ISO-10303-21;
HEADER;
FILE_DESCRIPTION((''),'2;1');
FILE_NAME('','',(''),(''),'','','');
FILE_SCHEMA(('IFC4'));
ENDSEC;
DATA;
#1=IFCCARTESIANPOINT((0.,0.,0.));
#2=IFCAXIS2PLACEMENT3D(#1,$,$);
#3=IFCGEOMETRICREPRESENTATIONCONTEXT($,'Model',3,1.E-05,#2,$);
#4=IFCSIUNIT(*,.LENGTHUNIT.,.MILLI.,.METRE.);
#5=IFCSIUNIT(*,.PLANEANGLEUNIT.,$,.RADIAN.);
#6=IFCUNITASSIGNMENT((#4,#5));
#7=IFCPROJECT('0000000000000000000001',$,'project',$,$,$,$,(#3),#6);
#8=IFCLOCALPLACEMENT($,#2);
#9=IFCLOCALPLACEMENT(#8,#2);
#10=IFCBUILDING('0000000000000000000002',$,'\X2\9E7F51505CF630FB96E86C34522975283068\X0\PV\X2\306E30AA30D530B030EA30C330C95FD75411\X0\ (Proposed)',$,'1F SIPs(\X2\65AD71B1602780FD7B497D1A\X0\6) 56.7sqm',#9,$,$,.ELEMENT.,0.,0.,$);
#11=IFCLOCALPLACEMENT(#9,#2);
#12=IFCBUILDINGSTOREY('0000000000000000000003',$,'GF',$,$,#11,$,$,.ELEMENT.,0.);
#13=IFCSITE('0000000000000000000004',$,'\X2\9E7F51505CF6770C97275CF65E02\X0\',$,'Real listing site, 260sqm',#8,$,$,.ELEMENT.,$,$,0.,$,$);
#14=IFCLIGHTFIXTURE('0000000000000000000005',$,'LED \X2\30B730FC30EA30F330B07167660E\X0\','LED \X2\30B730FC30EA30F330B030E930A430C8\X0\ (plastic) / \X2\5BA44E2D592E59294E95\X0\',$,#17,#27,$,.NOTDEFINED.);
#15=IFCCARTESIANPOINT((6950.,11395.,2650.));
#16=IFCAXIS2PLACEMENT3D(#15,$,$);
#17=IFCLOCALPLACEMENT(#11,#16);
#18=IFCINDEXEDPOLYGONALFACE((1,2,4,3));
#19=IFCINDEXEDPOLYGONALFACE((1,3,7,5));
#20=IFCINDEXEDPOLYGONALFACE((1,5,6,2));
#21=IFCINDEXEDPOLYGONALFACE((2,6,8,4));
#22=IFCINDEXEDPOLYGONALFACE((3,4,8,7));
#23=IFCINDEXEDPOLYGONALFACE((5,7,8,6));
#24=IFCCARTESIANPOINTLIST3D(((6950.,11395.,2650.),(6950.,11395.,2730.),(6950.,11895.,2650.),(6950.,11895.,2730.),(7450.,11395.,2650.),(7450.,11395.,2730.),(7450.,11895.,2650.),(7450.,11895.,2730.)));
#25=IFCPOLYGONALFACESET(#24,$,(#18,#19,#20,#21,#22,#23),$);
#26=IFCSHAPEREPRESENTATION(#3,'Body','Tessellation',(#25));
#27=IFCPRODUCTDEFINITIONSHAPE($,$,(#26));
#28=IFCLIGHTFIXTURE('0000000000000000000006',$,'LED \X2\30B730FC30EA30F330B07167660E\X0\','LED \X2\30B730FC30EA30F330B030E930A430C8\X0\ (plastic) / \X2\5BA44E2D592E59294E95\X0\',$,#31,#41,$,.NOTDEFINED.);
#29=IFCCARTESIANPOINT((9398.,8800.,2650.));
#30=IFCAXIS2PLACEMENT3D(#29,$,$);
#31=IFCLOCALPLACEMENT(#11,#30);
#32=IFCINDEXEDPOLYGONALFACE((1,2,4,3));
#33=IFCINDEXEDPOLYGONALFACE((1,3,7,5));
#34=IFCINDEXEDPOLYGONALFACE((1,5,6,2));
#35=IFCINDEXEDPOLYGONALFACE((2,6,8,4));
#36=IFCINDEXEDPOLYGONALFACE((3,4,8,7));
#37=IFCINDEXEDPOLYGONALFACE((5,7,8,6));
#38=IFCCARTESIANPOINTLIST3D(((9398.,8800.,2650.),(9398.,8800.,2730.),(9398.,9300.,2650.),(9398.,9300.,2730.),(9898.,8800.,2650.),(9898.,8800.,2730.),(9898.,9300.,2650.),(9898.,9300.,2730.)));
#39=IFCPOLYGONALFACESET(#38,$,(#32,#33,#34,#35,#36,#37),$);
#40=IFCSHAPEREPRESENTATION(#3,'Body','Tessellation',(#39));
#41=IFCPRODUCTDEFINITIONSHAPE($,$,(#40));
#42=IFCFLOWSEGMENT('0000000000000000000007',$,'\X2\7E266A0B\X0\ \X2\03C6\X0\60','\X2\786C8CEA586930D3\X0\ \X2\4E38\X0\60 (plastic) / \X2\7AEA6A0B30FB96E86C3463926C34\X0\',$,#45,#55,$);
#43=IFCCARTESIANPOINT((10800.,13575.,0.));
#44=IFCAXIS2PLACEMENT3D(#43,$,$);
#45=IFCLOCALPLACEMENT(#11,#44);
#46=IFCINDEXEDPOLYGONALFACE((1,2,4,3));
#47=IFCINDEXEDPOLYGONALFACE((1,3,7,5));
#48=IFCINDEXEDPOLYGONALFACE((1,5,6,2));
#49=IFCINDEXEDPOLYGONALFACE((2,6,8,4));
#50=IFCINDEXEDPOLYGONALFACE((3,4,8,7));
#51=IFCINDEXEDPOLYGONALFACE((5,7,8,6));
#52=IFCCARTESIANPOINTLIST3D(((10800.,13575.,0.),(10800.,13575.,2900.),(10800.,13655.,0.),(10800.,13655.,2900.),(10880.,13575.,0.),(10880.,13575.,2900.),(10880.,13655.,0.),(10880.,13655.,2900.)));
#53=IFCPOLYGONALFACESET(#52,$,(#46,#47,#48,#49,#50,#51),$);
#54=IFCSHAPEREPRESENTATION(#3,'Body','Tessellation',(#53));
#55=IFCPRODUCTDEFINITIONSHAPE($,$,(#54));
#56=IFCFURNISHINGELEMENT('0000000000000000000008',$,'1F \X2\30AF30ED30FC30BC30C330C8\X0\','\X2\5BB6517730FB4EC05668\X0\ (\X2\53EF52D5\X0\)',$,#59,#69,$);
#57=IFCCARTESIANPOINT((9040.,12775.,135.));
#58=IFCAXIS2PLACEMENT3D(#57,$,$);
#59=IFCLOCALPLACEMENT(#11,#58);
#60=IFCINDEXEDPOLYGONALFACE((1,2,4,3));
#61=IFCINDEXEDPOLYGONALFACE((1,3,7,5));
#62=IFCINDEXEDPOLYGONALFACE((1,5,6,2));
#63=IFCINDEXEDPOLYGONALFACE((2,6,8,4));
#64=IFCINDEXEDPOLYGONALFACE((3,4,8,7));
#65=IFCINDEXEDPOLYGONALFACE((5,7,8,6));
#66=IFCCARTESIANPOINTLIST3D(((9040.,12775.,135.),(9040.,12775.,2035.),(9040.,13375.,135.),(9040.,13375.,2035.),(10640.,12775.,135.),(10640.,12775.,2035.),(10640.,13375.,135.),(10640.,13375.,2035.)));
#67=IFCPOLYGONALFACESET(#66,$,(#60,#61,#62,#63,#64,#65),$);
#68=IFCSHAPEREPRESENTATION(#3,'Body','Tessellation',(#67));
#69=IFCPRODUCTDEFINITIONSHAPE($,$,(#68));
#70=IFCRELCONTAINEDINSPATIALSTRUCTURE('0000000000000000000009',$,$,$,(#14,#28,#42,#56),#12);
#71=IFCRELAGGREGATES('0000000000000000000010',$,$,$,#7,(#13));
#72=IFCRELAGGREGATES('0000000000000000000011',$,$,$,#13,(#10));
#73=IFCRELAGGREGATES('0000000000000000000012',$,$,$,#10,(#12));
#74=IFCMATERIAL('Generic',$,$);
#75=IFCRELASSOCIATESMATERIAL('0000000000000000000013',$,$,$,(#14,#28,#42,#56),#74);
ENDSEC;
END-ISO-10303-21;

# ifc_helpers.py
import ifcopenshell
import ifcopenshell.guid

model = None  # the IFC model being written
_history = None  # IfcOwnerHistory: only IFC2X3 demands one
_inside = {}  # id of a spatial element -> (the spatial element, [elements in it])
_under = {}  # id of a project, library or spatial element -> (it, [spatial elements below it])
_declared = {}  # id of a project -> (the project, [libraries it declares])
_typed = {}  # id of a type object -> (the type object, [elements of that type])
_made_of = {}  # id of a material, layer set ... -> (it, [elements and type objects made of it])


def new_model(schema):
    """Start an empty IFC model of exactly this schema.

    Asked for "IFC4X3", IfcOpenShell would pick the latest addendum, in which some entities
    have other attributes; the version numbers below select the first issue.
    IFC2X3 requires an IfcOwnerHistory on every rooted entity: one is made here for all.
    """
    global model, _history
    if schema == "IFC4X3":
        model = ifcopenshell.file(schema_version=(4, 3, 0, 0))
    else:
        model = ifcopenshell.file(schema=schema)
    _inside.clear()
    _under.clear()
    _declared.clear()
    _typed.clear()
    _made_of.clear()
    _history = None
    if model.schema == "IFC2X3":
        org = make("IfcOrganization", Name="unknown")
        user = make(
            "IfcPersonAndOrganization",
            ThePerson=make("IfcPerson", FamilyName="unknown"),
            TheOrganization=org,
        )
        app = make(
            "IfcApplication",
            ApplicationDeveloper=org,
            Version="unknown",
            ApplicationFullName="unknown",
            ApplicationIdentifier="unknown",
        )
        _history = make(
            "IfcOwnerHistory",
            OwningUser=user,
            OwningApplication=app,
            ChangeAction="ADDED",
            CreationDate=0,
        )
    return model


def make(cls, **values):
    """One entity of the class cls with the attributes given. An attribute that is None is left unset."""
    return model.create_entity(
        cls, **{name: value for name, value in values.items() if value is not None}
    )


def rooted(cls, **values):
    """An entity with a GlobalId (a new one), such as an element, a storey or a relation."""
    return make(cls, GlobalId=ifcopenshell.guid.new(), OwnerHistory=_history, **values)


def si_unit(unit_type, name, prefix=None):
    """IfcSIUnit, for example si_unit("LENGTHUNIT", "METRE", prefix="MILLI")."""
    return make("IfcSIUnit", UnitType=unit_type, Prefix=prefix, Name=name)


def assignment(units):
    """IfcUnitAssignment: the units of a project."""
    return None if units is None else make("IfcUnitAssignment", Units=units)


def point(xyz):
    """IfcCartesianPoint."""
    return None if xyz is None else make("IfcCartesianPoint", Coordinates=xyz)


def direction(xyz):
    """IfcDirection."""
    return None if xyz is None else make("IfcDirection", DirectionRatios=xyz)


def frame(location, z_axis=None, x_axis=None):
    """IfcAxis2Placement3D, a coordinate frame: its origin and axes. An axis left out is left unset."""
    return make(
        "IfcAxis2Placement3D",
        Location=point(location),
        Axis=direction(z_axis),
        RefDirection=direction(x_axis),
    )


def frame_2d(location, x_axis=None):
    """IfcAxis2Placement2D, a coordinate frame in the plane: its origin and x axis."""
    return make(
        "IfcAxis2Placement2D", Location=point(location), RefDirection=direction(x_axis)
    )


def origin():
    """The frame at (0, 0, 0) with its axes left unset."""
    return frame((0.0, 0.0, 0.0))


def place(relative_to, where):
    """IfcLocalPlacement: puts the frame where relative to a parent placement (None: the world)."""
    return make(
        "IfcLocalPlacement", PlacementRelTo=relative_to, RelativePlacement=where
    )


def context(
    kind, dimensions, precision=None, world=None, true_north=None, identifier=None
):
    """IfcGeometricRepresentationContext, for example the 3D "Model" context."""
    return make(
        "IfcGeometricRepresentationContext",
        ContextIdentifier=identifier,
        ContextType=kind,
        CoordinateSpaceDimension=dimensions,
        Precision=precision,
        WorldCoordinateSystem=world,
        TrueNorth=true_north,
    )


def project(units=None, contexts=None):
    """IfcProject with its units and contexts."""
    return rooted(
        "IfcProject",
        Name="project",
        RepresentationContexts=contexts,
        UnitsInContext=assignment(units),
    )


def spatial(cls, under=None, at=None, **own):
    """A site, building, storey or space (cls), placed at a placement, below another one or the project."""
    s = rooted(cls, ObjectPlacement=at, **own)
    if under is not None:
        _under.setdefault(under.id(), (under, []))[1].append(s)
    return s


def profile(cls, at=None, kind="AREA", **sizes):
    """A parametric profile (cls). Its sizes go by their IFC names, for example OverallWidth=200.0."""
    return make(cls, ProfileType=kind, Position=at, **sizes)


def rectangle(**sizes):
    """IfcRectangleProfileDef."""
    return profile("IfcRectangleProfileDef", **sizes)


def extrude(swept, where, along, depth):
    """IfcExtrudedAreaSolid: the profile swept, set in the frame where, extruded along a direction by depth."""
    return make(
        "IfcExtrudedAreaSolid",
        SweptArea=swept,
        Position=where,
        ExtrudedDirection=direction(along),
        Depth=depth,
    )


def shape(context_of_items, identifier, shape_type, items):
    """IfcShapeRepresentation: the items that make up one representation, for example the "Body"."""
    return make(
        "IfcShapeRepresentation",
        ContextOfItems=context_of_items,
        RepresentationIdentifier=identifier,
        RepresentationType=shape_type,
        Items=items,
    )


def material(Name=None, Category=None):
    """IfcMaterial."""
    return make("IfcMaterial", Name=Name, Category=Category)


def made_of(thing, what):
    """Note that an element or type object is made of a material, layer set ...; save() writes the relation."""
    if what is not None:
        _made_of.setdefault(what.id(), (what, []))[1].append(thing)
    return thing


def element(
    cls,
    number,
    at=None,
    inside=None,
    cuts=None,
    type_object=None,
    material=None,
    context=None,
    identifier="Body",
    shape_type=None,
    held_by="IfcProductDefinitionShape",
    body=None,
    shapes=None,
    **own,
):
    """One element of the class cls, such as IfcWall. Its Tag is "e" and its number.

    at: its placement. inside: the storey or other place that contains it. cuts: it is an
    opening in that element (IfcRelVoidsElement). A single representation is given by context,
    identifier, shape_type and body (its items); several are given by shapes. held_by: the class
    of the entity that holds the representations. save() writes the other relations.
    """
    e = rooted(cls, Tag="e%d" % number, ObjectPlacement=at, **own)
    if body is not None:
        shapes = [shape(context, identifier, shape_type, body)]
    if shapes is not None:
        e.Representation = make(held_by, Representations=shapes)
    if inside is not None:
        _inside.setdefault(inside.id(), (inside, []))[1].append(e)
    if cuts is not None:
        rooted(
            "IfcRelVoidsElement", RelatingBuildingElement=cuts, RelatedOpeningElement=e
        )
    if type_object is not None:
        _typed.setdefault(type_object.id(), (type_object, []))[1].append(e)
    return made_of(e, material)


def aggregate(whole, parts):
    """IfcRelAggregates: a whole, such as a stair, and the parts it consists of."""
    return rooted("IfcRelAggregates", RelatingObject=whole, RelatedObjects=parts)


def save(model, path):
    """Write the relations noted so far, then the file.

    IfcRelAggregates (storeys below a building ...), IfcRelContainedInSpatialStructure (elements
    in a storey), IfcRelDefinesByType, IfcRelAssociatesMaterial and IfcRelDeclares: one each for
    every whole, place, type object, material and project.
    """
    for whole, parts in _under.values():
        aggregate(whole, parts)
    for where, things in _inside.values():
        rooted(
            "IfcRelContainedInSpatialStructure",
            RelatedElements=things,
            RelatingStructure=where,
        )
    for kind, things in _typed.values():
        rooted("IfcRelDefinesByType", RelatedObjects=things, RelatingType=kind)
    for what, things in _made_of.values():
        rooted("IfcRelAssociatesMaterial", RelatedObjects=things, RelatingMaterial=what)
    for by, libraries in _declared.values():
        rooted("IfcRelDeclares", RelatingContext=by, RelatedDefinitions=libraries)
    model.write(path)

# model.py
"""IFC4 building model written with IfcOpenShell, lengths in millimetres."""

from ifc_helpers import new_model, si_unit, frame, frame_2d, origin, place, context, project, spatial, rectangle, extrude, material, element, save


model = new_model("IFC4")

# Units and contexts
model_context = context("Model", 3, precision=1e-05, world=origin())
ifc_project = project(units=[si_unit("LENGTHUNIT", "METRE", prefix="MILLI"), si_unit("PLANEANGLEUNIT", "RADIAN")], contexts=[model_context])

# Site, building, storey
site_placement = place(None, origin())
site = spatial("IfcSite", under=ifc_project, at=site_placement, Name="鹿児島県霧島市", ObjectType="Real listing site, 260sqm", CompositionType="ELEMENT", RefElevation=0.0)
building_placement = place(site_placement, origin())
building = spatial("IfcBuilding", under=site, at=building_placement, Name="鹿児島・雨水利用とPVのオフグリッド志向 (Proposed)", ObjectType="1F SIPs(断熱性能等級6) 56.7sqm", CompositionType="ELEMENT", ElevationOfRefHeight=0.0, ElevationOfTerrain=0.0)
storey_placement = place(building_placement, origin())
storey = spatial("IfcBuildingStorey", under=building, at=storey_placement, Name="GF", CompositionType="ELEMENT", Elevation=0.0)

# Shared definitions
ifc_material_1 = material(Name="Generic")

# Light fixtures
light_fixture_1_placement = place(storey_placement, frame((6950.0, 11395.0, 2650.0)))
element("IfcLightFixture", 1, at=light_fixture_1_placement, inside=storey, material=ifc_material_1, Name="LED シーリング照明", Description="LED シーリングライト (plastic) / 室中央天井", PredefinedType="NOTDEFINED", context=model_context, shape_type="SweptSolid", body=[
    extrude(rectangle(XDim=500.0, YDim=500.0, at=frame_2d((250.0, 250.0))), frame((6950.0, 11395.0, 2650.0)), (0.0, 0.0, 1.0), 80.0),
])
light_fixture_2_placement = place(storey_placement, frame((9398.0, 8800.0, 2650.0)))
element("IfcLightFixture", 2, at=light_fixture_2_placement, inside=storey, material=ifc_material_1, Name="LED シーリング照明", Description="LED シーリングライト (plastic) / 室中央天井", PredefinedType="NOTDEFINED", context=model_context, shape_type="SweptSolid", body=[
    extrude(rectangle(XDim=500.0, YDim=500.0, at=frame_2d((250.0, 250.0))), frame((9398.0, 8800.0, 2650.0)), (0.0, 0.0, 1.0), 80.0),
])

# Flow segment
flow_segment_placement = place(storey_placement, frame((10800.0, 13575.0, 0.0)))
element("IfcFlowSegment", 3, at=flow_segment_placement, inside=storey, material=ifc_material_1, Name="縦樋 φ60", Description="硬質塩ビ 丸60 (plastic) / 竪樋・雨水排水", context=model_context, shape_type="SweptSolid", body=[
    extrude(rectangle(XDim=80.0, YDim=80.0, at=frame_2d((40.0, 40.0))), frame((10800.0, 13575.0, 0.0)), (0.0, 0.0, 1.0), 2900.0),
])

# Furnishing element
furnishing_placement = place(storey_placement, frame((9040.0, 12775.0, 135.0)))
element("IfcFurnishingElement", 4, at=furnishing_placement, inside=storey, material=ifc_material_1, Name="1F クローゼット", Description="家具・什器 (可動)", context=model_context, shape_type="SweptSolid", body=[
    extrude(rectangle(XDim=1600.0, YDim=600.0, at=frame_2d((800.0, 300.0))), frame((9040.0, 12775.0, 135.0)), (0.0, 0.0, 1.0), 1900.0),
])

save(model, "model.ifc")
